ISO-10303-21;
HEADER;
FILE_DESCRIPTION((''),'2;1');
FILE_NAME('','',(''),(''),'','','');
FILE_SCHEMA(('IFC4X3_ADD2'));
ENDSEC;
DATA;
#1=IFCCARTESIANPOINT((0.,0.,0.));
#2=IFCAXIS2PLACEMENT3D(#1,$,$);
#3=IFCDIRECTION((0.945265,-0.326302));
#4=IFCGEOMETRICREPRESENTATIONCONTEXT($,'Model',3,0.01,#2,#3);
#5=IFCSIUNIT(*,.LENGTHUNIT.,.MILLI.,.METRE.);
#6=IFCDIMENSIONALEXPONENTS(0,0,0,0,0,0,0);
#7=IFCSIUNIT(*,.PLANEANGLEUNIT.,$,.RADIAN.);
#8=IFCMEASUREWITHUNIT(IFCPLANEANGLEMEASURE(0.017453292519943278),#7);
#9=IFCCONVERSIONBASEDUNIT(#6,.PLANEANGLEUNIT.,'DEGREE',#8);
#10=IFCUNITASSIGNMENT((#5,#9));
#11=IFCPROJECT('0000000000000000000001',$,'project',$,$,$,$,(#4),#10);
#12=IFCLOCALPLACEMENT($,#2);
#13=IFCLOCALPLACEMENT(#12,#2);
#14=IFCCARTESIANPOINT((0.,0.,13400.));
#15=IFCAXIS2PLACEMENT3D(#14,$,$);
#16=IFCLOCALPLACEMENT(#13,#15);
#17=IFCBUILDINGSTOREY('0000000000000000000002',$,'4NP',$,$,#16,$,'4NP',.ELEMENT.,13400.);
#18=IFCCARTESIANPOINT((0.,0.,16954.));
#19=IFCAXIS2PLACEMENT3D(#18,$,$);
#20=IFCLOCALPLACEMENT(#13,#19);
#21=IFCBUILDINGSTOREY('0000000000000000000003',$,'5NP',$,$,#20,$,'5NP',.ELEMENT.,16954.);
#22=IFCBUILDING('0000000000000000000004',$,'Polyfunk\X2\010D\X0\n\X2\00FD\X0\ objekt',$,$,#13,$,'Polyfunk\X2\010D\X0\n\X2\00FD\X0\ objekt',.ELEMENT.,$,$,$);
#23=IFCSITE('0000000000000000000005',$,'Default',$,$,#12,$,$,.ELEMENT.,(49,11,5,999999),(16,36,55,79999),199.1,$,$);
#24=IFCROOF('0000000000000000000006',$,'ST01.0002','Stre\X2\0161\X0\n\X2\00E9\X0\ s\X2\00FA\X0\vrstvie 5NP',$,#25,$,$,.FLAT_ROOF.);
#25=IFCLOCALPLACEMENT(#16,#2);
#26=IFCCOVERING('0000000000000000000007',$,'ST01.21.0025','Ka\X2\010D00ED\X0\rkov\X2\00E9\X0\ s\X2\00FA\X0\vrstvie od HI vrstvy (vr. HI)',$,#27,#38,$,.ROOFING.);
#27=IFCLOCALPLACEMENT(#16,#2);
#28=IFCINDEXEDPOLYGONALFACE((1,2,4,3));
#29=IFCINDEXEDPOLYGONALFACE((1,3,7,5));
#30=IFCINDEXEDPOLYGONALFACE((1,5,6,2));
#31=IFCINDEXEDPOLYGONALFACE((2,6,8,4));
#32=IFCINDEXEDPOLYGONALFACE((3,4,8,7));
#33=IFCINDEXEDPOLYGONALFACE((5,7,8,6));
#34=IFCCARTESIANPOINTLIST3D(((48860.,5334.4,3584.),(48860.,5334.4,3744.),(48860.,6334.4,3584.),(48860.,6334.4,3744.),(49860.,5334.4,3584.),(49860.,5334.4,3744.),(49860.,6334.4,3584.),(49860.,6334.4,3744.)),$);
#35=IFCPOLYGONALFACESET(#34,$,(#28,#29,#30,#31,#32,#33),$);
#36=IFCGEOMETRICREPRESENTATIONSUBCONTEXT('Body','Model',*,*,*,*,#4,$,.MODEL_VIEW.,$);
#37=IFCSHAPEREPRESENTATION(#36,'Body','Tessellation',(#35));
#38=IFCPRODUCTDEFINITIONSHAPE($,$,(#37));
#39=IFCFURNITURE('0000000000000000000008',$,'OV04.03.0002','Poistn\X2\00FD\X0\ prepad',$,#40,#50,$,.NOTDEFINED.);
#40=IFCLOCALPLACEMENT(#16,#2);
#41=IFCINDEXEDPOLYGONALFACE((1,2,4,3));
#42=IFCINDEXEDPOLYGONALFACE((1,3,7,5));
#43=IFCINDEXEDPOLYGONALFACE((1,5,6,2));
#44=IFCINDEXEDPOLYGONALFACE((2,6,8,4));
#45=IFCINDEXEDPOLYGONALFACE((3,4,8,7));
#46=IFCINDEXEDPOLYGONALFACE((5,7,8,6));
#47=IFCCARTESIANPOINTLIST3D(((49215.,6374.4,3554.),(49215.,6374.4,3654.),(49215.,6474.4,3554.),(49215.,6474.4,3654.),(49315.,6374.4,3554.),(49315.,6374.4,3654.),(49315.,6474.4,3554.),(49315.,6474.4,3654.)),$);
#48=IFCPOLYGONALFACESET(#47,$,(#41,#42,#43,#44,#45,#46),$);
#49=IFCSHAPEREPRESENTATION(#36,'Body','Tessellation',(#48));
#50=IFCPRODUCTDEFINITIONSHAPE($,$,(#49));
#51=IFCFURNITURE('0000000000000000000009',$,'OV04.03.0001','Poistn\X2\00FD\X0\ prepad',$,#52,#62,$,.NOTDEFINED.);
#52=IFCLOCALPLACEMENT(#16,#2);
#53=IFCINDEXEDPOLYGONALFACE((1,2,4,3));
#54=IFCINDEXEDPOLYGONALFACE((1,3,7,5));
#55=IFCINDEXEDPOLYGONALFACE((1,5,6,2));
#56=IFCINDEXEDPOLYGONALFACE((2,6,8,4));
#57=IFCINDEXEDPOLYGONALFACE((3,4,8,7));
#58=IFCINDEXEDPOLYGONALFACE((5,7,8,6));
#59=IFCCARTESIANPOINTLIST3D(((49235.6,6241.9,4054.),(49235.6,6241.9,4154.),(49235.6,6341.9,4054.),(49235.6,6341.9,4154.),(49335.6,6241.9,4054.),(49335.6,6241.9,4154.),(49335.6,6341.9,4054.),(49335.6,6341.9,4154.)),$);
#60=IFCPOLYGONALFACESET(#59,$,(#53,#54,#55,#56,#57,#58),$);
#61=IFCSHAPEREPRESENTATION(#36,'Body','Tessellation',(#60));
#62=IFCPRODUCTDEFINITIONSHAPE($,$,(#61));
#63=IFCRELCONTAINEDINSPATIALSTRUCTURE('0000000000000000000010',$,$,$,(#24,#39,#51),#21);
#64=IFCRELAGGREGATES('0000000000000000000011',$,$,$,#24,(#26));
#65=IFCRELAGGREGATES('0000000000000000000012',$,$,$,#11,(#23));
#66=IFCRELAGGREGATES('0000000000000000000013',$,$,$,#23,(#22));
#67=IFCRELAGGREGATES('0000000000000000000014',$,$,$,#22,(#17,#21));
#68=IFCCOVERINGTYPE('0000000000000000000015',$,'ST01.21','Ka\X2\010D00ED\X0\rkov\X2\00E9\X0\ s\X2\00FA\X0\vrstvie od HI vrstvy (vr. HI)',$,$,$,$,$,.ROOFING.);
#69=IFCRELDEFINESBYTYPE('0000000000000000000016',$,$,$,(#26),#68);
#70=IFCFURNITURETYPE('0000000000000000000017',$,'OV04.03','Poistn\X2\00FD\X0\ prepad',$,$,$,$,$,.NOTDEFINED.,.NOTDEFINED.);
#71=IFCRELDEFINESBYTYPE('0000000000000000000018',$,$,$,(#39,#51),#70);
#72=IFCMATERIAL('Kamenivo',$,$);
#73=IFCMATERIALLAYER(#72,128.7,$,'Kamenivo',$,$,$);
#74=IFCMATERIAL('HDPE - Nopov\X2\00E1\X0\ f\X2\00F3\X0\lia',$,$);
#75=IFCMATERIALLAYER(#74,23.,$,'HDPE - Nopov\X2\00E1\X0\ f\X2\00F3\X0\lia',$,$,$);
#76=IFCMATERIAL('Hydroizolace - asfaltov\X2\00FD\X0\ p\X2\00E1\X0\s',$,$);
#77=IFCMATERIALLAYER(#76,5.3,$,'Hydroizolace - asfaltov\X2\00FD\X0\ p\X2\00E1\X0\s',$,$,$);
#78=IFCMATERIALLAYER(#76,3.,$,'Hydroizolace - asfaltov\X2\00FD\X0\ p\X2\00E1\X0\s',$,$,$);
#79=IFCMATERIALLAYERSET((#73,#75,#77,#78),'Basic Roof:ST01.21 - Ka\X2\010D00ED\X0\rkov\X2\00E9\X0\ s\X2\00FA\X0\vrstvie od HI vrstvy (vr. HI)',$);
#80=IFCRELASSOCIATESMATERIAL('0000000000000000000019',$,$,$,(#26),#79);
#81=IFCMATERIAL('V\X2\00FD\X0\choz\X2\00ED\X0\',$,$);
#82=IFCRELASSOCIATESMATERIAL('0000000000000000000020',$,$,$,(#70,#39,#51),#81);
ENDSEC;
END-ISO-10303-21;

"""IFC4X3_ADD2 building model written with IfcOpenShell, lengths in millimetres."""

from ifc_helpers import new_model, entity, si_unit, converted_unit, direction, frame, frame_2d, origin, origin_2d_with_axis, place, context, subcontext, project, spatial, rectangle, extrude, source, transform, mapped, material, layer, layer_set, type_object, type_shapes, element, aggregate, save


model = new_model("IFC4X3_ADD2")

# Units and contexts
model_context = context("Model", 3, precision=0.01, world=origin(), true_north=direction((0.945265, -0.326302)))
body_context = subcontext(model_context, "Body", "Model", "MODEL_VIEW")
ifc_project = project(units=[si_unit("LENGTHUNIT", "METRE", prefix="MILLI"), converted_unit("PLANEANGLEUNIT", "DEGREE", entity("IfcPlaneAngleMeasure", 0.017453292519943278), si_unit("PLANEANGLEUNIT", "RADIAN"), dimensions=[0, 0, 0, 0, 0, 0, 0])], contexts=[model_context])

# Site, building, storey
site_placement = place(None, origin())
site = spatial("IfcSite", under=ifc_project, at=site_placement, Name="Default", CompositionType="ELEMENT", RefLatitude=(49, 11, 5, 999999), RefLongitude=(16, 36, 55, 79999), RefElevation=199.1)
building_placement = place(site_placement, origin())
building = spatial("IfcBuilding", under=site, at=building_placement, Name="Polyfunkčný objekt", LongName="Polyfunkčný objekt", CompositionType="ELEMENT")
storey_1_placement = place(building_placement, frame((0.0, 0.0, 13400.0)))
storey_1 = spatial("IfcBuildingStorey", under=building, at=storey_1_placement, Name="4NP", LongName="4NP", CompositionType="ELEMENT", Elevation=13400.0)

# Shared definitions
storey_2_placement = place(building_placement, frame((0.0, 0.0, 16954.0)))
storey_2 = spatial("IfcBuildingStorey", under=building, at=storey_2_placement, Name="5NP", LongName="5NP", CompositionType="ELEMENT", Elevation=16954.0)

# Roof, covering
roof = element("IfcRoof", 1, inside=storey_2, Name="ST01.0002", Description="Strešné súvrstvie 5NP", PredefinedType="FLAT_ROOF")
ifc_material_1 = material(Name="Kamenivo")
ifc_layer_1 = layer(ifc_material_1, 128.7, Name="Kamenivo")
ifc_material_2 = material(Name="HDPE - Nopová fólia")
ifc_layer_2 = layer(ifc_material_2, 23.0, Name="HDPE - Nopová fólia")
ifc_material_3 = material(Name="Hydroizolace - asfaltový pás")
ifc_layer_3 = layer(ifc_material_3, 5.3, Name="Hydroizolace - asfaltový pás")
ifc_layer_4 = layer(ifc_material_3, 3.0, Name="Hydroizolace - asfaltový pás")
ifc_layer_set_1 = layer_set([ifc_layer_1, ifc_layer_2, ifc_layer_3, ifc_layer_4], Name="Basic Roof:ST01.21 - Kačírkové súvrstvie od HI vrstvy (vr. HI)")
covering_type_1 = type_object("IfcCoveringType", Name="ST01.21", Description="Kačírkové súvrstvie od HI vrstvy (vr. HI)", PredefinedType="ROOFING")
placement_1 = place(storey_2_placement, frame((48860.0, 5334.4, 30.0)))
covering_1_placement = place(placement_1, origin())
covering_1 = element("IfcCovering", 2, at=covering_1_placement, type_object=covering_type_1, material=ifc_layer_set_1, Name="ST01.21.0025", Description="Kačírkové súvrstvie od HI vrstvy (vr. HI)", PredefinedType="ROOFING", context=body_context, shape_type="SweptSolid", body=[
    extrude(rectangle(XDim=1000.0, YDim=1000.0, at=frame_2d((0.0, 0.0), x_axis=(-1.0, 0.0))), frame((500.0, 500.0, 0.0)), (0.0, 0.0, 1.0), 160.0),
])
aggregate(roof, [covering_1])

# Furniture
ifc_material_4 = material(Name="Výchozí")
furniture_type = type_object("IfcFurnitureType", Name="OV04.03", Description="Poistný prepad", AssemblyPlace="NOTDEFINED", PredefinedType="NOTDEFINED", material=ifc_material_4)
shared_shape_1 = source(origin(), body_context, "Body", "SweptSolid", [
    extrude(rectangle(XDim=100.0, YDim=100.0, at=origin_2d_with_axis()), frame((0.0, 0.0, 0.0), z_axis=(0.0, 0.0, 1.0), x_axis=(0.0, 1.0, 0.0)), (0.0, 0.0, 1.0), 100.0),
])
type_shapes(furniture_type, [shared_shape_1])
for number, where, name in (
    (3, (49265.0, 6424.4, 0.0), "OV04.03.0002"),
    (4, (49285.6, 6291.9, 500.0), "OV04.03.0001"),
):
    element("IfcFurniture", number, at=place(storey_2_placement, frame(where)), inside=storey_2, type_object=furniture_type, material=ifc_material_4, Name=name, Description="Poistný prepad", PredefinedType="NOTDEFINED", context=body_context, shape_type="MappedRepresentation", body=[
        mapped(shared_shape_1, transform((0.0, 0.0, 0.0), scale=1.0)),
    ])

save(model, "model.ifc")
